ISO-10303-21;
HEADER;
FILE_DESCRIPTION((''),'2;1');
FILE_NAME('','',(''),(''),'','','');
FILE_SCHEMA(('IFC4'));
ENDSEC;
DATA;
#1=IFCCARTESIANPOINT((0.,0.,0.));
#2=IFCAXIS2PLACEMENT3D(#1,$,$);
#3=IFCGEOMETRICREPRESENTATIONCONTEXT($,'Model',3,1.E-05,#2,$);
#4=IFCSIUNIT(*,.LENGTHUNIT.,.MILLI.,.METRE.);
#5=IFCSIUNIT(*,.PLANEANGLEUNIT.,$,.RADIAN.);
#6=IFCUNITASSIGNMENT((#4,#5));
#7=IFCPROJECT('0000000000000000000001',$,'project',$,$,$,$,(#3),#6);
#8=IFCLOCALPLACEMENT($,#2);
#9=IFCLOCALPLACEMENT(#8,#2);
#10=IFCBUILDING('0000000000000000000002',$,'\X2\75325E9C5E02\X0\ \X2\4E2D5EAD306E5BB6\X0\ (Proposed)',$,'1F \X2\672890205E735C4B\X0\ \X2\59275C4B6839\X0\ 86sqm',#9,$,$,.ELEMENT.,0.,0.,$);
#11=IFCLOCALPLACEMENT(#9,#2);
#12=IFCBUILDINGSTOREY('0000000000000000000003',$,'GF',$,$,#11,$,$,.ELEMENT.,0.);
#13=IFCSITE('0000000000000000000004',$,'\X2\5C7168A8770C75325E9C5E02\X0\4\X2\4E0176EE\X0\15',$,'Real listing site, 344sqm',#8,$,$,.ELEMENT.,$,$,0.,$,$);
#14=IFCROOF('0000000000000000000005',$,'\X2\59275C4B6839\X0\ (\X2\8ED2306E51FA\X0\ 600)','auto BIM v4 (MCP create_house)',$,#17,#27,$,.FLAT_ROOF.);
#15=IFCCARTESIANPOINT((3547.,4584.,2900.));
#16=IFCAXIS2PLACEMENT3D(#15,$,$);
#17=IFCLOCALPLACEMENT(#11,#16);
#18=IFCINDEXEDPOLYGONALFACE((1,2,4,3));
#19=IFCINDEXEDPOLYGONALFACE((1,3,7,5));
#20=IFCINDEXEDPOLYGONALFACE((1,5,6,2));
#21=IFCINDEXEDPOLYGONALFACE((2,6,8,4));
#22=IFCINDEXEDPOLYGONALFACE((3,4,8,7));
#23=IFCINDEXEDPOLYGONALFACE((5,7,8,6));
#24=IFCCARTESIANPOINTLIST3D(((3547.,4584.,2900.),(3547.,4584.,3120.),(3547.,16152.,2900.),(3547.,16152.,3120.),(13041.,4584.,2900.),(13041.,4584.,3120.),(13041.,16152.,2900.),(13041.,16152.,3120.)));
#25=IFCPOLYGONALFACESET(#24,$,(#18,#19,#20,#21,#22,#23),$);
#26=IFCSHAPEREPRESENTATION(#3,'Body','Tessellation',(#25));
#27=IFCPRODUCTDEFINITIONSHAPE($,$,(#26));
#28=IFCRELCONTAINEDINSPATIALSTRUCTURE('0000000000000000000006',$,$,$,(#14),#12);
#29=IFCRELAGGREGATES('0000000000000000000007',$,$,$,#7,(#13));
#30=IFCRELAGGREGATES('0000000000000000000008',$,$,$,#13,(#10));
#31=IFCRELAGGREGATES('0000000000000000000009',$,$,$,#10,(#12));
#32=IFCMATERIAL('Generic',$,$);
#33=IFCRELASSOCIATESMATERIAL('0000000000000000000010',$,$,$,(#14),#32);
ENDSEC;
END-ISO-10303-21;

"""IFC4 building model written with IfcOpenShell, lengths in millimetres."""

from ifc_helpers import new_model, si_unit, frame, frame_2d, origin, place, context, project, spatial, rectangle, extrude, material, element, save


model = new_model("IFC4")

# Units and contexts
model_context = context("Model", 3, precision=1e-05, world=origin())
ifc_project = project(units=[si_unit("LENGTHUNIT", "METRE", prefix="MILLI"), si_unit("PLANEANGLEUNIT", "RADIAN")], contexts=[model_context])

# Site, building, storey
site_placement = place(None, origin())
site = spatial("IfcSite", under=ifc_project, at=site_placement, Name="山梨県甲府市4丁目15", ObjectType="Real listing site, 344sqm", CompositionType="ELEMENT", RefElevation=0.0)
building_placement = place(site_placement, origin())
building = spatial("IfcBuilding", under=site, at=building_placement, Name="甲府市 中庭の家 (Proposed)", ObjectType="1F 木造平屋 大屋根 86sqm", CompositionType="ELEMENT", ElevationOfRefHeight=0.0, ElevationOfTerrain=0.0)
storey_placement = place(building_placement, origin())
storey = spatial("IfcBuildingStorey", under=building, at=storey_placement, Name="GF", CompositionType="ELEMENT", Elevation=0.0)

# Shared definitions
ifc_material = material(Name="Generic")

# Roof
roof_placement = place(storey_placement, frame((3547.0, 4584.0, 2900.0)))
element("IfcRoof", 1, at=roof_placement, inside=storey, material=ifc_material, Name="大屋根 (軒の出 600)", Description="auto BIM v4 (MCP create_house)", PredefinedType="FLAT_ROOF", context=model_context, shape_type="SweptSolid", body=[
    extrude(rectangle(XDim=9494.0, YDim=11568.0, at=frame_2d((4747.0, 5784.0))), frame((3547.0, 4584.0, 2900.0)), (0.0, 0.0, 1.0), 220.0),
])

save(model, "model.ifc")
